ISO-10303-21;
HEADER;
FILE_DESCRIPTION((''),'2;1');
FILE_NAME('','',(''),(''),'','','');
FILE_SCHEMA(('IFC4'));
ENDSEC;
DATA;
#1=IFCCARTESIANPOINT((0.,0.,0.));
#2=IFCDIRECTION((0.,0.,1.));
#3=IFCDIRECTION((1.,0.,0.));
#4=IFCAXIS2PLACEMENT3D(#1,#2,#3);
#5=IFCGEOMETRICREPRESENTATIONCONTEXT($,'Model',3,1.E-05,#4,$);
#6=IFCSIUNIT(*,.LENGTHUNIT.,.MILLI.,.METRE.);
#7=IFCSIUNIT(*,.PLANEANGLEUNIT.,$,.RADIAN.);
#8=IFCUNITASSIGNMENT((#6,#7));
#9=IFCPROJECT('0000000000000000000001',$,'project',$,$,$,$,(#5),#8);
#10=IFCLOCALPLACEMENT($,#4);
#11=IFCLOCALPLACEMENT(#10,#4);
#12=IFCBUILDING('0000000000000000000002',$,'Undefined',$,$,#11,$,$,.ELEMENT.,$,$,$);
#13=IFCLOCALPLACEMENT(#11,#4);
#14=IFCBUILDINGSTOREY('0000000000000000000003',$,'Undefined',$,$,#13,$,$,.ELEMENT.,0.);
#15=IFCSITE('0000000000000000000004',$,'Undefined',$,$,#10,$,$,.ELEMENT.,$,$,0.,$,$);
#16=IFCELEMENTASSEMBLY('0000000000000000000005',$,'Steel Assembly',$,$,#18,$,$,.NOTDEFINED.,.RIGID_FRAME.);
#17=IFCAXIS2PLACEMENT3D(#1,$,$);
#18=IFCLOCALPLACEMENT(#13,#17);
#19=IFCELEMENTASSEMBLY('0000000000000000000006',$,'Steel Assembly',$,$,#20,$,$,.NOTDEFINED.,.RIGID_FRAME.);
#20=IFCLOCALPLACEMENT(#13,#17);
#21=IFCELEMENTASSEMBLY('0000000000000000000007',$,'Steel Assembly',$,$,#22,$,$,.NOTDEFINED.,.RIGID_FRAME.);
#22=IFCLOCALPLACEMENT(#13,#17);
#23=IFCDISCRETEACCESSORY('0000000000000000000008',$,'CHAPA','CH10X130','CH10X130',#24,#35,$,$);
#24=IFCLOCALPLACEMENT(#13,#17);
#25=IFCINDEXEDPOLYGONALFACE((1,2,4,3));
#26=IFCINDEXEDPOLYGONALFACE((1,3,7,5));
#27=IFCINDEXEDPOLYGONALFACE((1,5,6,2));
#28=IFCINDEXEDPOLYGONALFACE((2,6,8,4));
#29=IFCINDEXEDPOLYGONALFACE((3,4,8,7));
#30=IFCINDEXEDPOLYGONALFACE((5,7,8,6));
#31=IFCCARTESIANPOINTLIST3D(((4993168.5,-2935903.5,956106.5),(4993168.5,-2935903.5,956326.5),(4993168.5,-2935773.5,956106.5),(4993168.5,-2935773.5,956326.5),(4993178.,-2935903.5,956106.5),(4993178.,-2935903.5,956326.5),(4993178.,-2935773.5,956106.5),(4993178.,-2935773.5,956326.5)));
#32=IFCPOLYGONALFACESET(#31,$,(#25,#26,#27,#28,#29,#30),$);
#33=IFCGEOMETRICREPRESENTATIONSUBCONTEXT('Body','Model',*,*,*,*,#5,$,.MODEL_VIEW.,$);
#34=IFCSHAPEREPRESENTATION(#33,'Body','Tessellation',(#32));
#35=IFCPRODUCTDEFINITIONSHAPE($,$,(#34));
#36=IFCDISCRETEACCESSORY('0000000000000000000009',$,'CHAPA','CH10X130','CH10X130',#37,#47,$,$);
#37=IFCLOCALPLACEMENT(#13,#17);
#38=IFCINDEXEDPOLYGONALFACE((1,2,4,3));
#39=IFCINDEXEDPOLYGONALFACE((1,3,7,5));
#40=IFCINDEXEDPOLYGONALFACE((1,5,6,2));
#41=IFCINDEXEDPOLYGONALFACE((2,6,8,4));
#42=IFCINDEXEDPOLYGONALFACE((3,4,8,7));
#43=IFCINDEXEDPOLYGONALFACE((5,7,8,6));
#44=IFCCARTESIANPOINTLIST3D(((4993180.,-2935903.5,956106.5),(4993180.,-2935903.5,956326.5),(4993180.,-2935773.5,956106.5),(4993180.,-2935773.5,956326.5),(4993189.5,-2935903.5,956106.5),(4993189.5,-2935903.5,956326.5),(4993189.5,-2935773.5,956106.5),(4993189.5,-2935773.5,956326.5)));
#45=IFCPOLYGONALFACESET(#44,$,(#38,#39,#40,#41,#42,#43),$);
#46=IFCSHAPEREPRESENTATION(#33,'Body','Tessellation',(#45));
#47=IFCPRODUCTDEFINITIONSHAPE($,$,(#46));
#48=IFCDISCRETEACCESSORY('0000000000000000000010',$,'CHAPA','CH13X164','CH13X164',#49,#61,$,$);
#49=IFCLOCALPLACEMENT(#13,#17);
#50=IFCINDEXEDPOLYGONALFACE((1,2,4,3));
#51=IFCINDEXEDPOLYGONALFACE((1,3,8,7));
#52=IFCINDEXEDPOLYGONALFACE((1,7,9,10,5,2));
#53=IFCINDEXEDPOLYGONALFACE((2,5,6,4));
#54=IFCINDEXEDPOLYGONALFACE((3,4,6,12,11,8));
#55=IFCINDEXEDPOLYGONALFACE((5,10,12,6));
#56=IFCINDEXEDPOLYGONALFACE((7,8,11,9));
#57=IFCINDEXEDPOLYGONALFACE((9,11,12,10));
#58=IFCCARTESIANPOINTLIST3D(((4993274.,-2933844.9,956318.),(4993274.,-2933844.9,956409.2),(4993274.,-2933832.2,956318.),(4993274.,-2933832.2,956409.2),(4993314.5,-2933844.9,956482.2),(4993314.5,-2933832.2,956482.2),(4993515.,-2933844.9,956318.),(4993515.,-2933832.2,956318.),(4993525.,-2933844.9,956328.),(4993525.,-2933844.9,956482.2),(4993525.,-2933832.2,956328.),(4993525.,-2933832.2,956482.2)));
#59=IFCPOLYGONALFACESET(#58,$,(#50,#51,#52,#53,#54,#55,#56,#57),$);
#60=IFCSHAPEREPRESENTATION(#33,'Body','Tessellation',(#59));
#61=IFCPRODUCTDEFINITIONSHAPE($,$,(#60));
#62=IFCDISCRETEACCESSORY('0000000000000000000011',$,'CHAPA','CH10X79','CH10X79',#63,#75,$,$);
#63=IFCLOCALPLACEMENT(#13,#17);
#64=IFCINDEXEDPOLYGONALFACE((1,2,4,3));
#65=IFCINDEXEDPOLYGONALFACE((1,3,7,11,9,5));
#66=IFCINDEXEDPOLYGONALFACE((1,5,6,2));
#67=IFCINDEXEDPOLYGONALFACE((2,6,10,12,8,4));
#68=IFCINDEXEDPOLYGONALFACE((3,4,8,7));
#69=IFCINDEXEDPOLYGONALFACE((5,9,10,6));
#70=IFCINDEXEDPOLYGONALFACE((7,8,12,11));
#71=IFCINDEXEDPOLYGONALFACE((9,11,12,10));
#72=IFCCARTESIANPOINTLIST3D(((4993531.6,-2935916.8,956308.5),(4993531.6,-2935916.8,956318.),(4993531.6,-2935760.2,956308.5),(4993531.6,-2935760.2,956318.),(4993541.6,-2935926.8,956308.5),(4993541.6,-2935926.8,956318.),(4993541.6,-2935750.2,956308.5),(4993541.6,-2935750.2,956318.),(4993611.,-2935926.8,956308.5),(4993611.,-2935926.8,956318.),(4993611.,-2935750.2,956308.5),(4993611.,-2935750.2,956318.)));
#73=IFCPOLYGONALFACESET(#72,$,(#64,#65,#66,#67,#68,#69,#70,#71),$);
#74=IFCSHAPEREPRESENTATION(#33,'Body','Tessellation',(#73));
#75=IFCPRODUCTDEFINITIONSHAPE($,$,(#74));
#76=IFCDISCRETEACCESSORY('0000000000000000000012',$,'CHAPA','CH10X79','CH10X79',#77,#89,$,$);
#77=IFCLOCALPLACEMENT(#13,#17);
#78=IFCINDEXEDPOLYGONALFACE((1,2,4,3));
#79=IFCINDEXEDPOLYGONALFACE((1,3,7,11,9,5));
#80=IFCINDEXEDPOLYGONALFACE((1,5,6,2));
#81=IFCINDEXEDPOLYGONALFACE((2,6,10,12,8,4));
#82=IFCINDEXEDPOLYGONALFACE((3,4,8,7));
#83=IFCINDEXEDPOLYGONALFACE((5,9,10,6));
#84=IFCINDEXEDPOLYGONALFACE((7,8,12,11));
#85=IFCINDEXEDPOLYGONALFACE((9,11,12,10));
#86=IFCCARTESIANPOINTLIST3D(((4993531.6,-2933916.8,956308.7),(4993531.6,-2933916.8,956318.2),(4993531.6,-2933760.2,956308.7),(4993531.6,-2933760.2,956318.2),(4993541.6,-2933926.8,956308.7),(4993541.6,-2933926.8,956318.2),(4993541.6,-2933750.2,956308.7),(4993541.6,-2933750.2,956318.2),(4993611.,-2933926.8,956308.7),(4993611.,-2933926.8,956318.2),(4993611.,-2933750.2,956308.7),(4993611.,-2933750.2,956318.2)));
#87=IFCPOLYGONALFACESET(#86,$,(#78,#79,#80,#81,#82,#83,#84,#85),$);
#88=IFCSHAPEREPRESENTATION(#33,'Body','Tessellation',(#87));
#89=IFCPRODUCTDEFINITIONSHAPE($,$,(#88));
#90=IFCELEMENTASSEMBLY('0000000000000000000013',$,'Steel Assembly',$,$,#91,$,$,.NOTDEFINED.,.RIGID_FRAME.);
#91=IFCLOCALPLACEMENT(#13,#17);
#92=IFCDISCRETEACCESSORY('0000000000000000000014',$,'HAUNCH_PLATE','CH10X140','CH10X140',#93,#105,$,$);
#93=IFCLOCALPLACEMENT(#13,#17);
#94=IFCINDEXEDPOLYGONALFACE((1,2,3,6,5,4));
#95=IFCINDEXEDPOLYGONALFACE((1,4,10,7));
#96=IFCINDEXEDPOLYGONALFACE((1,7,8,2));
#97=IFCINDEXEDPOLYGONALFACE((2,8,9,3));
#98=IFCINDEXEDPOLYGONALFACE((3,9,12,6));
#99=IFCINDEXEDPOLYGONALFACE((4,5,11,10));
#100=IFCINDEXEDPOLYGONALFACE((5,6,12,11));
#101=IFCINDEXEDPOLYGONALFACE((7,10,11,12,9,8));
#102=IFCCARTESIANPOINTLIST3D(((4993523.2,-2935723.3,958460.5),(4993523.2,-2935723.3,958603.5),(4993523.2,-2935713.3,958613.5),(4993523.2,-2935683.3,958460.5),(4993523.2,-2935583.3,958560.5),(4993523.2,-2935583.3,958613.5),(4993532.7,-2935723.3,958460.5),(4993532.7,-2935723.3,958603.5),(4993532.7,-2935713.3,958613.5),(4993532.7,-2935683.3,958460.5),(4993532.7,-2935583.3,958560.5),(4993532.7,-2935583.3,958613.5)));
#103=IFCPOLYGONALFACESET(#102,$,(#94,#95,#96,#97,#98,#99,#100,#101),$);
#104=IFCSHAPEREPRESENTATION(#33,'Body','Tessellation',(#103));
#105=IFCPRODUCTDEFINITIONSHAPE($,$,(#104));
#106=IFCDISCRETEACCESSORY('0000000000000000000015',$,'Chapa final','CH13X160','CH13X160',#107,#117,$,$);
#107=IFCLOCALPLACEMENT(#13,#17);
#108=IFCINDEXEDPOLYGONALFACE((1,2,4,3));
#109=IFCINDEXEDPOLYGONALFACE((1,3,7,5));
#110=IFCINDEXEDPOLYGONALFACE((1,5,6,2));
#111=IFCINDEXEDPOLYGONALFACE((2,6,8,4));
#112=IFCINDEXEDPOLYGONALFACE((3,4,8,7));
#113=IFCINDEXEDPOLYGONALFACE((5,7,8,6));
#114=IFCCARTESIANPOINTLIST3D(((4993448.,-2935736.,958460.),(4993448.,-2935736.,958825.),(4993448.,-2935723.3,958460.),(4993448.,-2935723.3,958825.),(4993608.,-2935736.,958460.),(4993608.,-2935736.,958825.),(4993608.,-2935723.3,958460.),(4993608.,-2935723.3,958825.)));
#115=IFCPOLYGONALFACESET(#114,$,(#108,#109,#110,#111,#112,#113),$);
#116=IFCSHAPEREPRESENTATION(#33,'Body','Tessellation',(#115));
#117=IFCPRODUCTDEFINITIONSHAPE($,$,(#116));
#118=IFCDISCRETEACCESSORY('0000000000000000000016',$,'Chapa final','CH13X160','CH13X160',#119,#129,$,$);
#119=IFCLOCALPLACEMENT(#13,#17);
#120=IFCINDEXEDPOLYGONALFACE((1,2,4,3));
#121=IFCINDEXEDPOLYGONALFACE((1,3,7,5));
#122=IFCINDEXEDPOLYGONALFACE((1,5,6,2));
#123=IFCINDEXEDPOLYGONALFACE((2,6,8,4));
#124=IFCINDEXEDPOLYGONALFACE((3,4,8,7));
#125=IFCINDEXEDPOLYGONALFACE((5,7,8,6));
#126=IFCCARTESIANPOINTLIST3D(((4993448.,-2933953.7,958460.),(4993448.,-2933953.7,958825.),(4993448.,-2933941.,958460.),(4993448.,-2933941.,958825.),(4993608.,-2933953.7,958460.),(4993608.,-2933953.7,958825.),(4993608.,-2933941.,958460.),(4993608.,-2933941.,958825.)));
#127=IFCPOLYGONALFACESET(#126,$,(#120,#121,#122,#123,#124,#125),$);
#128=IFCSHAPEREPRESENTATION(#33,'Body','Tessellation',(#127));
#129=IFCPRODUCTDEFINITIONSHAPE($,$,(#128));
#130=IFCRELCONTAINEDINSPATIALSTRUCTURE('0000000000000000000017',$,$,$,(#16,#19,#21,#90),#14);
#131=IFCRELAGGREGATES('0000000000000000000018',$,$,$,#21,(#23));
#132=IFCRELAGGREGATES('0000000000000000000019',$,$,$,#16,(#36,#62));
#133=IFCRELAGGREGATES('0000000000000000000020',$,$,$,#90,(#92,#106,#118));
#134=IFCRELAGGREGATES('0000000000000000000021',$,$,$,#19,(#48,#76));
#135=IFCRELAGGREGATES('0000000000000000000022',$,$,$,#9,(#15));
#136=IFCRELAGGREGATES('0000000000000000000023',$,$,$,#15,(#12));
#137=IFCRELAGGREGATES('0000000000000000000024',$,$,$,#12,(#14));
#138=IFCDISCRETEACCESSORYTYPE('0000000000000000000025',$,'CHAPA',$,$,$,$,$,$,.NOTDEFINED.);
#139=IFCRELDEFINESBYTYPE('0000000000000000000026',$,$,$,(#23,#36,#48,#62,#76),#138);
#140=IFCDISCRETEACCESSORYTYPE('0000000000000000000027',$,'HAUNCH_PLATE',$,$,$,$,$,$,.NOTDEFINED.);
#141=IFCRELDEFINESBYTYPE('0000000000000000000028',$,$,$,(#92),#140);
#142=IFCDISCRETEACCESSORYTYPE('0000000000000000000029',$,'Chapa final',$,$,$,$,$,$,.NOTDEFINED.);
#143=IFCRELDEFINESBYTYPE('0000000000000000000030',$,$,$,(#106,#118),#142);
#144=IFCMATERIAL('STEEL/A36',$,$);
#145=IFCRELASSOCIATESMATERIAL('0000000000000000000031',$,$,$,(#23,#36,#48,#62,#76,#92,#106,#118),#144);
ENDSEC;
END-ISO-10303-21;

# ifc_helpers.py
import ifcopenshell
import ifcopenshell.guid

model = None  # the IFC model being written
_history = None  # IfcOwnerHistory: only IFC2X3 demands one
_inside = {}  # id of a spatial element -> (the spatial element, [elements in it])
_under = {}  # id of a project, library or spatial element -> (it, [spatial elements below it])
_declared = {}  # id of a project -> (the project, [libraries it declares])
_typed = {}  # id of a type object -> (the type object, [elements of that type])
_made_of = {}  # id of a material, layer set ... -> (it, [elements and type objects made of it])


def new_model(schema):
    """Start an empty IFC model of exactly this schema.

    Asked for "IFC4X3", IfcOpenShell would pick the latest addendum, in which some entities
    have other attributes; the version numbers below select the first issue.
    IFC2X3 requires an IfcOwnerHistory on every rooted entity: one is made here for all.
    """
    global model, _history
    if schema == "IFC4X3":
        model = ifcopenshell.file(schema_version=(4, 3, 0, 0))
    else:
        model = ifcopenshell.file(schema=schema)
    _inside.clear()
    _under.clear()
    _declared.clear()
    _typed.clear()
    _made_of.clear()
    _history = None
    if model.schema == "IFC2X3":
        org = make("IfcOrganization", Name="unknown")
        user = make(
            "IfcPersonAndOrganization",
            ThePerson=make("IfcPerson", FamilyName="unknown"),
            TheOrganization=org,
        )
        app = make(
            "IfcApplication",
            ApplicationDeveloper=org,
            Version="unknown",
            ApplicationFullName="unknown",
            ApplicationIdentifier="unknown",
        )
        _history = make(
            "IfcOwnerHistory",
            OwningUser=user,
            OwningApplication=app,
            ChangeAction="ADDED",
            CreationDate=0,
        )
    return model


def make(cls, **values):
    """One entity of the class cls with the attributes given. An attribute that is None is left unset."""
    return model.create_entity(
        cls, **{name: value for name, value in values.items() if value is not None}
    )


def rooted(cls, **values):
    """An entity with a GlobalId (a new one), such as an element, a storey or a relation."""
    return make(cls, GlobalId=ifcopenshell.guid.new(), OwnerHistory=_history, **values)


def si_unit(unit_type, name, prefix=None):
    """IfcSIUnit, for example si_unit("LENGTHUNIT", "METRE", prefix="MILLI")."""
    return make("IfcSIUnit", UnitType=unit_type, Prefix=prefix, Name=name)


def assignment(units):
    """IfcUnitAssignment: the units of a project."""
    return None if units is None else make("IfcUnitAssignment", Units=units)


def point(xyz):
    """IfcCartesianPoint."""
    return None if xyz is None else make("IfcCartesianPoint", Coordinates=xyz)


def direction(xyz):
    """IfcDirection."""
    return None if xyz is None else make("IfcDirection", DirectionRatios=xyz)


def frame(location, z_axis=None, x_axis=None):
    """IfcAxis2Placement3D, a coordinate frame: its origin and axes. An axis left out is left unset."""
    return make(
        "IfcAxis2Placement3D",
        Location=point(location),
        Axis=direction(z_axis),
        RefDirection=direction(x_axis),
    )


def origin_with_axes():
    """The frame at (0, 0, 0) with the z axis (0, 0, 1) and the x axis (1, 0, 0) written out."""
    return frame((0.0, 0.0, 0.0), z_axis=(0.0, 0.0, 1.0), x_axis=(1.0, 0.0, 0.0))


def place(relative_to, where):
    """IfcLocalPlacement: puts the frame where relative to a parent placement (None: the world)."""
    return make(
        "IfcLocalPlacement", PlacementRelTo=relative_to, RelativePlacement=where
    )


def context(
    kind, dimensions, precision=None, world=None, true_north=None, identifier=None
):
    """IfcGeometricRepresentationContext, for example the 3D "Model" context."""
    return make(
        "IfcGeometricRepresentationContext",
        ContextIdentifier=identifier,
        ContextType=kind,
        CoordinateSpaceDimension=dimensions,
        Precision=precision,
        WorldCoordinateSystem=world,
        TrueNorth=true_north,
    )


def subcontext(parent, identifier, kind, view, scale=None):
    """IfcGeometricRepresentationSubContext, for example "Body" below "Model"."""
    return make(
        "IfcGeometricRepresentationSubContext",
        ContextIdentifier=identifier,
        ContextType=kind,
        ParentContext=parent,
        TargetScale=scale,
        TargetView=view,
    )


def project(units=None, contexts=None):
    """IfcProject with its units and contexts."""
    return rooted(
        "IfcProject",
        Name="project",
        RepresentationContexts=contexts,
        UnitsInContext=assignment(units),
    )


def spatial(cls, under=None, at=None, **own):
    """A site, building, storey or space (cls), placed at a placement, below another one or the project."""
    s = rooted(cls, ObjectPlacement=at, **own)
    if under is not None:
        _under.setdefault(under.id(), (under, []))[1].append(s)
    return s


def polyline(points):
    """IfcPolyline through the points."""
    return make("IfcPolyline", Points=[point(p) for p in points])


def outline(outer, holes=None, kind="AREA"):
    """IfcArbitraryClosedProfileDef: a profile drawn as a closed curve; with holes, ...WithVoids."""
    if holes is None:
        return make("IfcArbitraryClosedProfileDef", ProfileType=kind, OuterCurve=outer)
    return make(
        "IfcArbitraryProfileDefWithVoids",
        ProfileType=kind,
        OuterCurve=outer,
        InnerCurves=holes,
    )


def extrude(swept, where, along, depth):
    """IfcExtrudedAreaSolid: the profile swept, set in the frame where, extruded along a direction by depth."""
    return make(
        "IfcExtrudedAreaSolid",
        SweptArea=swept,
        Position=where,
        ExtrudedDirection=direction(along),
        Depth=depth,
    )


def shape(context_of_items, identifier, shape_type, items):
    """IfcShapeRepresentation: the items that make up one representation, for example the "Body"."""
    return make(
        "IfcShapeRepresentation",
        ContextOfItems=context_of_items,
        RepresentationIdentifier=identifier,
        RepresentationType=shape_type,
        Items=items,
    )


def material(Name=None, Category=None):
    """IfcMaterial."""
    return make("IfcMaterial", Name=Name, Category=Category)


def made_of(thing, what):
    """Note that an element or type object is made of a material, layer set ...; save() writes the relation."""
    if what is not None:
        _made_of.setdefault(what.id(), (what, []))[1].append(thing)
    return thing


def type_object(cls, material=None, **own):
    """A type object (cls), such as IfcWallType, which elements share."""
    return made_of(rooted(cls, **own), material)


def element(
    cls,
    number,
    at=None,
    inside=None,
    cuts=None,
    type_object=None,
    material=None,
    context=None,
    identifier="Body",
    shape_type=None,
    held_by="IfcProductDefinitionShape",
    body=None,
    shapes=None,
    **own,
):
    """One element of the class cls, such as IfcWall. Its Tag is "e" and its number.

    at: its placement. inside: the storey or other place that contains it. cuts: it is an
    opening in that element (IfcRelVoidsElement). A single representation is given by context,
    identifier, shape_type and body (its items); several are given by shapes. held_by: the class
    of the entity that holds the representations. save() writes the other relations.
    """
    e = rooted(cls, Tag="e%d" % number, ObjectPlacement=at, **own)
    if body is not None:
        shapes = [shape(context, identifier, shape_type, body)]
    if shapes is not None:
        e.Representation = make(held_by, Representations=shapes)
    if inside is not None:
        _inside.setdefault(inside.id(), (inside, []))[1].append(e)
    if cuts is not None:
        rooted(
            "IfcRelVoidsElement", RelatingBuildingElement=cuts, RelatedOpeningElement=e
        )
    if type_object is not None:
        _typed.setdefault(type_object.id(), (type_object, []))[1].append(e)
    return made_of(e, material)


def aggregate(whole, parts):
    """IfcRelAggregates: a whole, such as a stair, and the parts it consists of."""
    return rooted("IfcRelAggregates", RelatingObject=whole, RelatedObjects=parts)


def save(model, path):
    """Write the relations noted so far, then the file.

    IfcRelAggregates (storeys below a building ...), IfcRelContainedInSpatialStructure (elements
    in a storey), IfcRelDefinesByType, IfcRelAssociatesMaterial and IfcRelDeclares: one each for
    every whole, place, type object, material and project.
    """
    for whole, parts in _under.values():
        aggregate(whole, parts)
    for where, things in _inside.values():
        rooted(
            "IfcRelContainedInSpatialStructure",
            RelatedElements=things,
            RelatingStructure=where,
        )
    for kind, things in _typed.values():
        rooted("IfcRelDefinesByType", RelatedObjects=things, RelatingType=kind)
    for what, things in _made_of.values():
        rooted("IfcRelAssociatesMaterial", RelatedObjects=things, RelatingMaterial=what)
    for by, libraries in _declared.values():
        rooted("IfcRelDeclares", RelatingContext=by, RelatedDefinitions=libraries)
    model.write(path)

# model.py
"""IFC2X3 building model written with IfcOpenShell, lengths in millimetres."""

from ifc_helpers import new_model, si_unit, frame, origin_with_axes, place, context, subcontext, project, spatial, polyline, outline, extrude, material, type_object, element, aggregate, save


model = new_model("IFC2X3")

# Units and contexts
model_context = context("Model", 3, precision=1e-05, world=origin_with_axes())
body_context = subcontext(model_context, "Body", "Model", "MODEL_VIEW")
ifc_project = project(units=[si_unit("LENGTHUNIT", "METRE", prefix="MILLI"), si_unit("PLANEANGLEUNIT", "RADIAN")], contexts=[model_context])

# Site, building, storey
site_placement = place(None, origin_with_axes())
site = spatial("IfcSite", under=ifc_project, at=site_placement, Name="Undefined", CompositionType="ELEMENT", RefElevation=0.0)
building_placement = place(site_placement, origin_with_axes())
building = spatial("IfcBuilding", under=site, at=building_placement, Name="Undefined", CompositionType="ELEMENT")
storey_placement = place(building_placement, origin_with_axes())
storey = spatial("IfcBuildingStorey", under=building, at=storey_placement, Name="Undefined", CompositionType="ELEMENT", Elevation=0.0)

# Shared definitions
ifc_material_1 = material(Name="STEEL/A36")

# Element assembly
assembly_1_placement = place(storey_placement, origin_with_axes())
assembly_1 = element("IfcElementAssembly", 1, at=assembly_1_placement, inside=storey, Name="Steel Assembly", AssemblyPlace="NOTDEFINED", PredefinedType="RIGID_FRAME")
discrete_accessory_type_1 = type_object("IfcDiscreteAccessoryType", Name="CHAPA")

# Element assemblies, discrete accessory
assembly_2_placement = place(storey_placement, origin_with_axes())
assembly_2 = element("IfcElementAssembly", 2, at=assembly_2_placement, inside=storey, Name="Steel Assembly", AssemblyPlace="NOTDEFINED", PredefinedType="RIGID_FRAME")
assembly_3_placement = place(storey_placement, origin_with_axes())
assembly_3 = element("IfcElementAssembly", 3, at=assembly_3_placement, inside=storey, Name="Steel Assembly", AssemblyPlace="NOTDEFINED", PredefinedType="RIGID_FRAME")
discrete_accessory_1_placement = place(assembly_3_placement, frame((4993173.2, -2935838.5, 956326.5), z_axis=(-1.0, 0.0, 0.0), x_axis=(0.0, 0.0, -1.0)))
discrete_accessory_1 = element("IfcDiscreteAccessory", 4, at=discrete_accessory_1_placement, type_object=discrete_accessory_type_1, material=ifc_material_1, Name="CHAPA", Description="CH10X130", ObjectType="CH10X130", context=body_context, shape_type="SweptSolid", body=[
    extrude(outline(polyline([(220.0, 65.0), (220.0, -65.0), (0.0, -65.0), (0.0, 65.0), (220.0, 65.0)])), frame((0.0, 0.0, -4.8), z_axis=(0.0, 0.0, 1.0), x_axis=(1.0, 0.0, 0.0)), (0.0, 0.0, 1.0), 9.5),
])
aggregate(assembly_3, [discrete_accessory_1])

# Discrete accessories
discrete_accessory_2_placement = place(assembly_1_placement, frame((4993184.7, -2935838.5, 956326.5), z_axis=(-1.0, 0.0, 0.0), x_axis=(0.0, 0.0, -1.0)))
discrete_accessory_2 = element("IfcDiscreteAccessory", 5, at=discrete_accessory_2_placement, type_object=discrete_accessory_type_1, material=ifc_material_1, Name="CHAPA", Description="CH10X130", ObjectType="CH10X130", context=body_context, shape_type="SweptSolid", body=[
    extrude(outline(polyline([(220.0, 65.0), (220.0, -65.0), (0.0, -65.0), (0.0, 65.0), (220.0, 65.0)])), frame((0.0, 0.0, -4.8), z_axis=(0.0, 0.0, 1.0), x_axis=(1.0, 0.0, 0.0)), (0.0, 0.0, 1.0), 9.5),
])
discrete_accessory_3_placement = place(assembly_2_placement, frame((4993525.0, -2933838.5, 956318.0), z_axis=(0.0, 1.0, 0.0), x_axis=(-1.0, 0.0, 0.0)))
discrete_accessory_3 = element("IfcDiscreteAccessory", 6, at=discrete_accessory_3_placement, type_object=discrete_accessory_type_1, material=ifc_material_1, Name="CHAPA", Description="CH13X164", ObjectType="CH13X164", context=body_context, shape_type="SweptSolid", body=[
    extrude(outline(polyline([(0.0, 10.0), (10.0, 0.0), (251.0, 0.0), (251.0, 91.2), (210.5, 164.2), (0.0, 164.2), (0.0, 10.0)])), frame((0.0, 0.0, -6.3), z_axis=(0.0, 0.0, 1.0), x_axis=(1.0, 0.0, 0.0)), (0.0, 0.0, 1.0), 12.7),
])
discrete_accessory_4_placement = place(assembly_1_placement, frame((4993531.6, -2935750.2, 956313.3), z_axis=(0.0, 0.0, -1.0), x_axis=(1.0, 0.0, 0.0)))
discrete_accessory_4 = element("IfcDiscreteAccessory", 7, at=discrete_accessory_4_placement, type_object=discrete_accessory_type_1, material=ifc_material_1, Name="CHAPA", Description="CH10X79", ObjectType="CH10X79", context=body_context, shape_type="SweptSolid", body=[
    extrude(outline(polyline([(0.0, 10.0), (10.0, 0.0), (79.4, 0.0), (79.4, 176.6), (10.0, 176.6), (0.0, 166.6), (0.0, 10.0)])), frame((0.0, 0.0, -4.8), z_axis=(0.0, 0.0, 1.0), x_axis=(1.0, 0.0, 0.0)), (0.0, 0.0, 1.0), 9.5),
])
aggregate(assembly_1, [discrete_accessory_2, discrete_accessory_4])
discrete_accessory_5_placement = place(assembly_2_placement, frame((4993611.0, -2933926.8, 956313.4), z_axis=(0.0, 0.0, -1.0), x_axis=(-1.0, 0.0, 0.0)))
discrete_accessory_5 = element("IfcDiscreteAccessory", 8, at=discrete_accessory_5_placement, type_object=discrete_accessory_type_1, material=ifc_material_1, Name="CHAPA", Description="CH10X79", ObjectType="CH10X79", context=body_context, shape_type="SweptSolid", body=[
    extrude(outline(polyline([(0.0, 0.0), (69.4, 0.0), (79.4, 10.0), (79.4, 166.6), (69.4, 176.6), (0.0, 176.6), (0.0, 0.0)])), frame((0.0, 0.0, -4.8), z_axis=(0.0, 0.0, 1.0), x_axis=(1.0, 0.0, 0.0)), (0.0, 0.0, 1.0), 9.5),
])

# Element assembly, discrete accessories
assembly_4_placement = place(storey_placement, origin_with_axes())
assembly_4 = element("IfcElementAssembly", 9, at=assembly_4_placement, inside=storey, Name="Steel Assembly", AssemblyPlace="NOTDEFINED", PredefinedType="RIGID_FRAME")
discrete_accessory_type_2 = type_object("IfcDiscreteAccessoryType", Name="HAUNCH_PLATE")
discrete_accessory_6_placement = place(assembly_4_placement, frame((4993528.0, -2935723.3, 958613.5), z_axis=(1.0, 0.0, 0.0), x_axis=(0.0, 0.0, -1.0)))
discrete_accessory_6 = element("IfcDiscreteAccessory", 10, at=discrete_accessory_6_placement, type_object=discrete_accessory_type_2, material=ifc_material_1, Name="HAUNCH_PLATE", Description="CH10X140", ObjectType="CH10X140", context=body_context, shape_type="SweptSolid", body=[
    extrude(outline(polyline([(0.0, 10.0), (10.0, 0.0), (153.0, 0.0), (153.0, 40.0), (53.0, 140.0), (0.0, 140.0), (0.0, 10.0)])), frame((0.0, 0.0, -4.8), z_axis=(0.0, 0.0, 1.0), x_axis=(1.0, 0.0, 0.0)), (0.0, 0.0, 1.0), 9.5),
])
discrete_accessory_type_3 = type_object("IfcDiscreteAccessoryType", Name="Chapa final")
discrete_accessory_7_placement = place(assembly_4_placement, frame((4993528.0, -2935729.7, 958460.0), z_axis=(0.0, 1.0, 0.0), x_axis=(0.0, 0.0, 1.0)))
discrete_accessory_7 = element("IfcDiscreteAccessory", 11, at=discrete_accessory_7_placement, type_object=discrete_accessory_type_3, material=ifc_material_1, Name="Chapa final", Description="CH13X160", ObjectType="CH13X160", context=body_context, shape_type="SweptSolid", body=[
    extrude(outline(polyline([(0.0, -80.0), (0.0, 80.0), (365.0, 80.0), (365.0, -80.0), (0.0, -80.0)])), frame((0.0, 0.0, -6.3), z_axis=(0.0, 0.0, 1.0), x_axis=(1.0, 0.0, 0.0)), (0.0, 0.0, 1.0), 12.7),
])
discrete_accessory_8_placement = place(assembly_4_placement, frame((4993528.0, -2933947.4, 958460.0), z_axis=(0.0, -1.0, 0.0), x_axis=(0.0, 0.0, 1.0)))
discrete_accessory_8 = element("IfcDiscreteAccessory", 12, at=discrete_accessory_8_placement, type_object=discrete_accessory_type_3, material=ifc_material_1, Name="Chapa final", Description="CH13X160", ObjectType="CH13X160", context=body_context, shape_type="SweptSolid", body=[
    extrude(outline(polyline([(0.0, 80.0), (365.0, 80.0), (365.0, -80.0), (0.0, -80.0), (0.0, 80.0)])), frame((0.0, 0.0, -6.3), z_axis=(0.0, 0.0, 1.0), x_axis=(1.0, 0.0, 0.0)), (0.0, 0.0, 1.0), 12.7),
])
aggregate(assembly_4, [discrete_accessory_6, discrete_accessory_7, discrete_accessory_8])

aggregate(assembly_2, [discrete_accessory_3, discrete_accessory_5])

save(model, "model.ifc")
